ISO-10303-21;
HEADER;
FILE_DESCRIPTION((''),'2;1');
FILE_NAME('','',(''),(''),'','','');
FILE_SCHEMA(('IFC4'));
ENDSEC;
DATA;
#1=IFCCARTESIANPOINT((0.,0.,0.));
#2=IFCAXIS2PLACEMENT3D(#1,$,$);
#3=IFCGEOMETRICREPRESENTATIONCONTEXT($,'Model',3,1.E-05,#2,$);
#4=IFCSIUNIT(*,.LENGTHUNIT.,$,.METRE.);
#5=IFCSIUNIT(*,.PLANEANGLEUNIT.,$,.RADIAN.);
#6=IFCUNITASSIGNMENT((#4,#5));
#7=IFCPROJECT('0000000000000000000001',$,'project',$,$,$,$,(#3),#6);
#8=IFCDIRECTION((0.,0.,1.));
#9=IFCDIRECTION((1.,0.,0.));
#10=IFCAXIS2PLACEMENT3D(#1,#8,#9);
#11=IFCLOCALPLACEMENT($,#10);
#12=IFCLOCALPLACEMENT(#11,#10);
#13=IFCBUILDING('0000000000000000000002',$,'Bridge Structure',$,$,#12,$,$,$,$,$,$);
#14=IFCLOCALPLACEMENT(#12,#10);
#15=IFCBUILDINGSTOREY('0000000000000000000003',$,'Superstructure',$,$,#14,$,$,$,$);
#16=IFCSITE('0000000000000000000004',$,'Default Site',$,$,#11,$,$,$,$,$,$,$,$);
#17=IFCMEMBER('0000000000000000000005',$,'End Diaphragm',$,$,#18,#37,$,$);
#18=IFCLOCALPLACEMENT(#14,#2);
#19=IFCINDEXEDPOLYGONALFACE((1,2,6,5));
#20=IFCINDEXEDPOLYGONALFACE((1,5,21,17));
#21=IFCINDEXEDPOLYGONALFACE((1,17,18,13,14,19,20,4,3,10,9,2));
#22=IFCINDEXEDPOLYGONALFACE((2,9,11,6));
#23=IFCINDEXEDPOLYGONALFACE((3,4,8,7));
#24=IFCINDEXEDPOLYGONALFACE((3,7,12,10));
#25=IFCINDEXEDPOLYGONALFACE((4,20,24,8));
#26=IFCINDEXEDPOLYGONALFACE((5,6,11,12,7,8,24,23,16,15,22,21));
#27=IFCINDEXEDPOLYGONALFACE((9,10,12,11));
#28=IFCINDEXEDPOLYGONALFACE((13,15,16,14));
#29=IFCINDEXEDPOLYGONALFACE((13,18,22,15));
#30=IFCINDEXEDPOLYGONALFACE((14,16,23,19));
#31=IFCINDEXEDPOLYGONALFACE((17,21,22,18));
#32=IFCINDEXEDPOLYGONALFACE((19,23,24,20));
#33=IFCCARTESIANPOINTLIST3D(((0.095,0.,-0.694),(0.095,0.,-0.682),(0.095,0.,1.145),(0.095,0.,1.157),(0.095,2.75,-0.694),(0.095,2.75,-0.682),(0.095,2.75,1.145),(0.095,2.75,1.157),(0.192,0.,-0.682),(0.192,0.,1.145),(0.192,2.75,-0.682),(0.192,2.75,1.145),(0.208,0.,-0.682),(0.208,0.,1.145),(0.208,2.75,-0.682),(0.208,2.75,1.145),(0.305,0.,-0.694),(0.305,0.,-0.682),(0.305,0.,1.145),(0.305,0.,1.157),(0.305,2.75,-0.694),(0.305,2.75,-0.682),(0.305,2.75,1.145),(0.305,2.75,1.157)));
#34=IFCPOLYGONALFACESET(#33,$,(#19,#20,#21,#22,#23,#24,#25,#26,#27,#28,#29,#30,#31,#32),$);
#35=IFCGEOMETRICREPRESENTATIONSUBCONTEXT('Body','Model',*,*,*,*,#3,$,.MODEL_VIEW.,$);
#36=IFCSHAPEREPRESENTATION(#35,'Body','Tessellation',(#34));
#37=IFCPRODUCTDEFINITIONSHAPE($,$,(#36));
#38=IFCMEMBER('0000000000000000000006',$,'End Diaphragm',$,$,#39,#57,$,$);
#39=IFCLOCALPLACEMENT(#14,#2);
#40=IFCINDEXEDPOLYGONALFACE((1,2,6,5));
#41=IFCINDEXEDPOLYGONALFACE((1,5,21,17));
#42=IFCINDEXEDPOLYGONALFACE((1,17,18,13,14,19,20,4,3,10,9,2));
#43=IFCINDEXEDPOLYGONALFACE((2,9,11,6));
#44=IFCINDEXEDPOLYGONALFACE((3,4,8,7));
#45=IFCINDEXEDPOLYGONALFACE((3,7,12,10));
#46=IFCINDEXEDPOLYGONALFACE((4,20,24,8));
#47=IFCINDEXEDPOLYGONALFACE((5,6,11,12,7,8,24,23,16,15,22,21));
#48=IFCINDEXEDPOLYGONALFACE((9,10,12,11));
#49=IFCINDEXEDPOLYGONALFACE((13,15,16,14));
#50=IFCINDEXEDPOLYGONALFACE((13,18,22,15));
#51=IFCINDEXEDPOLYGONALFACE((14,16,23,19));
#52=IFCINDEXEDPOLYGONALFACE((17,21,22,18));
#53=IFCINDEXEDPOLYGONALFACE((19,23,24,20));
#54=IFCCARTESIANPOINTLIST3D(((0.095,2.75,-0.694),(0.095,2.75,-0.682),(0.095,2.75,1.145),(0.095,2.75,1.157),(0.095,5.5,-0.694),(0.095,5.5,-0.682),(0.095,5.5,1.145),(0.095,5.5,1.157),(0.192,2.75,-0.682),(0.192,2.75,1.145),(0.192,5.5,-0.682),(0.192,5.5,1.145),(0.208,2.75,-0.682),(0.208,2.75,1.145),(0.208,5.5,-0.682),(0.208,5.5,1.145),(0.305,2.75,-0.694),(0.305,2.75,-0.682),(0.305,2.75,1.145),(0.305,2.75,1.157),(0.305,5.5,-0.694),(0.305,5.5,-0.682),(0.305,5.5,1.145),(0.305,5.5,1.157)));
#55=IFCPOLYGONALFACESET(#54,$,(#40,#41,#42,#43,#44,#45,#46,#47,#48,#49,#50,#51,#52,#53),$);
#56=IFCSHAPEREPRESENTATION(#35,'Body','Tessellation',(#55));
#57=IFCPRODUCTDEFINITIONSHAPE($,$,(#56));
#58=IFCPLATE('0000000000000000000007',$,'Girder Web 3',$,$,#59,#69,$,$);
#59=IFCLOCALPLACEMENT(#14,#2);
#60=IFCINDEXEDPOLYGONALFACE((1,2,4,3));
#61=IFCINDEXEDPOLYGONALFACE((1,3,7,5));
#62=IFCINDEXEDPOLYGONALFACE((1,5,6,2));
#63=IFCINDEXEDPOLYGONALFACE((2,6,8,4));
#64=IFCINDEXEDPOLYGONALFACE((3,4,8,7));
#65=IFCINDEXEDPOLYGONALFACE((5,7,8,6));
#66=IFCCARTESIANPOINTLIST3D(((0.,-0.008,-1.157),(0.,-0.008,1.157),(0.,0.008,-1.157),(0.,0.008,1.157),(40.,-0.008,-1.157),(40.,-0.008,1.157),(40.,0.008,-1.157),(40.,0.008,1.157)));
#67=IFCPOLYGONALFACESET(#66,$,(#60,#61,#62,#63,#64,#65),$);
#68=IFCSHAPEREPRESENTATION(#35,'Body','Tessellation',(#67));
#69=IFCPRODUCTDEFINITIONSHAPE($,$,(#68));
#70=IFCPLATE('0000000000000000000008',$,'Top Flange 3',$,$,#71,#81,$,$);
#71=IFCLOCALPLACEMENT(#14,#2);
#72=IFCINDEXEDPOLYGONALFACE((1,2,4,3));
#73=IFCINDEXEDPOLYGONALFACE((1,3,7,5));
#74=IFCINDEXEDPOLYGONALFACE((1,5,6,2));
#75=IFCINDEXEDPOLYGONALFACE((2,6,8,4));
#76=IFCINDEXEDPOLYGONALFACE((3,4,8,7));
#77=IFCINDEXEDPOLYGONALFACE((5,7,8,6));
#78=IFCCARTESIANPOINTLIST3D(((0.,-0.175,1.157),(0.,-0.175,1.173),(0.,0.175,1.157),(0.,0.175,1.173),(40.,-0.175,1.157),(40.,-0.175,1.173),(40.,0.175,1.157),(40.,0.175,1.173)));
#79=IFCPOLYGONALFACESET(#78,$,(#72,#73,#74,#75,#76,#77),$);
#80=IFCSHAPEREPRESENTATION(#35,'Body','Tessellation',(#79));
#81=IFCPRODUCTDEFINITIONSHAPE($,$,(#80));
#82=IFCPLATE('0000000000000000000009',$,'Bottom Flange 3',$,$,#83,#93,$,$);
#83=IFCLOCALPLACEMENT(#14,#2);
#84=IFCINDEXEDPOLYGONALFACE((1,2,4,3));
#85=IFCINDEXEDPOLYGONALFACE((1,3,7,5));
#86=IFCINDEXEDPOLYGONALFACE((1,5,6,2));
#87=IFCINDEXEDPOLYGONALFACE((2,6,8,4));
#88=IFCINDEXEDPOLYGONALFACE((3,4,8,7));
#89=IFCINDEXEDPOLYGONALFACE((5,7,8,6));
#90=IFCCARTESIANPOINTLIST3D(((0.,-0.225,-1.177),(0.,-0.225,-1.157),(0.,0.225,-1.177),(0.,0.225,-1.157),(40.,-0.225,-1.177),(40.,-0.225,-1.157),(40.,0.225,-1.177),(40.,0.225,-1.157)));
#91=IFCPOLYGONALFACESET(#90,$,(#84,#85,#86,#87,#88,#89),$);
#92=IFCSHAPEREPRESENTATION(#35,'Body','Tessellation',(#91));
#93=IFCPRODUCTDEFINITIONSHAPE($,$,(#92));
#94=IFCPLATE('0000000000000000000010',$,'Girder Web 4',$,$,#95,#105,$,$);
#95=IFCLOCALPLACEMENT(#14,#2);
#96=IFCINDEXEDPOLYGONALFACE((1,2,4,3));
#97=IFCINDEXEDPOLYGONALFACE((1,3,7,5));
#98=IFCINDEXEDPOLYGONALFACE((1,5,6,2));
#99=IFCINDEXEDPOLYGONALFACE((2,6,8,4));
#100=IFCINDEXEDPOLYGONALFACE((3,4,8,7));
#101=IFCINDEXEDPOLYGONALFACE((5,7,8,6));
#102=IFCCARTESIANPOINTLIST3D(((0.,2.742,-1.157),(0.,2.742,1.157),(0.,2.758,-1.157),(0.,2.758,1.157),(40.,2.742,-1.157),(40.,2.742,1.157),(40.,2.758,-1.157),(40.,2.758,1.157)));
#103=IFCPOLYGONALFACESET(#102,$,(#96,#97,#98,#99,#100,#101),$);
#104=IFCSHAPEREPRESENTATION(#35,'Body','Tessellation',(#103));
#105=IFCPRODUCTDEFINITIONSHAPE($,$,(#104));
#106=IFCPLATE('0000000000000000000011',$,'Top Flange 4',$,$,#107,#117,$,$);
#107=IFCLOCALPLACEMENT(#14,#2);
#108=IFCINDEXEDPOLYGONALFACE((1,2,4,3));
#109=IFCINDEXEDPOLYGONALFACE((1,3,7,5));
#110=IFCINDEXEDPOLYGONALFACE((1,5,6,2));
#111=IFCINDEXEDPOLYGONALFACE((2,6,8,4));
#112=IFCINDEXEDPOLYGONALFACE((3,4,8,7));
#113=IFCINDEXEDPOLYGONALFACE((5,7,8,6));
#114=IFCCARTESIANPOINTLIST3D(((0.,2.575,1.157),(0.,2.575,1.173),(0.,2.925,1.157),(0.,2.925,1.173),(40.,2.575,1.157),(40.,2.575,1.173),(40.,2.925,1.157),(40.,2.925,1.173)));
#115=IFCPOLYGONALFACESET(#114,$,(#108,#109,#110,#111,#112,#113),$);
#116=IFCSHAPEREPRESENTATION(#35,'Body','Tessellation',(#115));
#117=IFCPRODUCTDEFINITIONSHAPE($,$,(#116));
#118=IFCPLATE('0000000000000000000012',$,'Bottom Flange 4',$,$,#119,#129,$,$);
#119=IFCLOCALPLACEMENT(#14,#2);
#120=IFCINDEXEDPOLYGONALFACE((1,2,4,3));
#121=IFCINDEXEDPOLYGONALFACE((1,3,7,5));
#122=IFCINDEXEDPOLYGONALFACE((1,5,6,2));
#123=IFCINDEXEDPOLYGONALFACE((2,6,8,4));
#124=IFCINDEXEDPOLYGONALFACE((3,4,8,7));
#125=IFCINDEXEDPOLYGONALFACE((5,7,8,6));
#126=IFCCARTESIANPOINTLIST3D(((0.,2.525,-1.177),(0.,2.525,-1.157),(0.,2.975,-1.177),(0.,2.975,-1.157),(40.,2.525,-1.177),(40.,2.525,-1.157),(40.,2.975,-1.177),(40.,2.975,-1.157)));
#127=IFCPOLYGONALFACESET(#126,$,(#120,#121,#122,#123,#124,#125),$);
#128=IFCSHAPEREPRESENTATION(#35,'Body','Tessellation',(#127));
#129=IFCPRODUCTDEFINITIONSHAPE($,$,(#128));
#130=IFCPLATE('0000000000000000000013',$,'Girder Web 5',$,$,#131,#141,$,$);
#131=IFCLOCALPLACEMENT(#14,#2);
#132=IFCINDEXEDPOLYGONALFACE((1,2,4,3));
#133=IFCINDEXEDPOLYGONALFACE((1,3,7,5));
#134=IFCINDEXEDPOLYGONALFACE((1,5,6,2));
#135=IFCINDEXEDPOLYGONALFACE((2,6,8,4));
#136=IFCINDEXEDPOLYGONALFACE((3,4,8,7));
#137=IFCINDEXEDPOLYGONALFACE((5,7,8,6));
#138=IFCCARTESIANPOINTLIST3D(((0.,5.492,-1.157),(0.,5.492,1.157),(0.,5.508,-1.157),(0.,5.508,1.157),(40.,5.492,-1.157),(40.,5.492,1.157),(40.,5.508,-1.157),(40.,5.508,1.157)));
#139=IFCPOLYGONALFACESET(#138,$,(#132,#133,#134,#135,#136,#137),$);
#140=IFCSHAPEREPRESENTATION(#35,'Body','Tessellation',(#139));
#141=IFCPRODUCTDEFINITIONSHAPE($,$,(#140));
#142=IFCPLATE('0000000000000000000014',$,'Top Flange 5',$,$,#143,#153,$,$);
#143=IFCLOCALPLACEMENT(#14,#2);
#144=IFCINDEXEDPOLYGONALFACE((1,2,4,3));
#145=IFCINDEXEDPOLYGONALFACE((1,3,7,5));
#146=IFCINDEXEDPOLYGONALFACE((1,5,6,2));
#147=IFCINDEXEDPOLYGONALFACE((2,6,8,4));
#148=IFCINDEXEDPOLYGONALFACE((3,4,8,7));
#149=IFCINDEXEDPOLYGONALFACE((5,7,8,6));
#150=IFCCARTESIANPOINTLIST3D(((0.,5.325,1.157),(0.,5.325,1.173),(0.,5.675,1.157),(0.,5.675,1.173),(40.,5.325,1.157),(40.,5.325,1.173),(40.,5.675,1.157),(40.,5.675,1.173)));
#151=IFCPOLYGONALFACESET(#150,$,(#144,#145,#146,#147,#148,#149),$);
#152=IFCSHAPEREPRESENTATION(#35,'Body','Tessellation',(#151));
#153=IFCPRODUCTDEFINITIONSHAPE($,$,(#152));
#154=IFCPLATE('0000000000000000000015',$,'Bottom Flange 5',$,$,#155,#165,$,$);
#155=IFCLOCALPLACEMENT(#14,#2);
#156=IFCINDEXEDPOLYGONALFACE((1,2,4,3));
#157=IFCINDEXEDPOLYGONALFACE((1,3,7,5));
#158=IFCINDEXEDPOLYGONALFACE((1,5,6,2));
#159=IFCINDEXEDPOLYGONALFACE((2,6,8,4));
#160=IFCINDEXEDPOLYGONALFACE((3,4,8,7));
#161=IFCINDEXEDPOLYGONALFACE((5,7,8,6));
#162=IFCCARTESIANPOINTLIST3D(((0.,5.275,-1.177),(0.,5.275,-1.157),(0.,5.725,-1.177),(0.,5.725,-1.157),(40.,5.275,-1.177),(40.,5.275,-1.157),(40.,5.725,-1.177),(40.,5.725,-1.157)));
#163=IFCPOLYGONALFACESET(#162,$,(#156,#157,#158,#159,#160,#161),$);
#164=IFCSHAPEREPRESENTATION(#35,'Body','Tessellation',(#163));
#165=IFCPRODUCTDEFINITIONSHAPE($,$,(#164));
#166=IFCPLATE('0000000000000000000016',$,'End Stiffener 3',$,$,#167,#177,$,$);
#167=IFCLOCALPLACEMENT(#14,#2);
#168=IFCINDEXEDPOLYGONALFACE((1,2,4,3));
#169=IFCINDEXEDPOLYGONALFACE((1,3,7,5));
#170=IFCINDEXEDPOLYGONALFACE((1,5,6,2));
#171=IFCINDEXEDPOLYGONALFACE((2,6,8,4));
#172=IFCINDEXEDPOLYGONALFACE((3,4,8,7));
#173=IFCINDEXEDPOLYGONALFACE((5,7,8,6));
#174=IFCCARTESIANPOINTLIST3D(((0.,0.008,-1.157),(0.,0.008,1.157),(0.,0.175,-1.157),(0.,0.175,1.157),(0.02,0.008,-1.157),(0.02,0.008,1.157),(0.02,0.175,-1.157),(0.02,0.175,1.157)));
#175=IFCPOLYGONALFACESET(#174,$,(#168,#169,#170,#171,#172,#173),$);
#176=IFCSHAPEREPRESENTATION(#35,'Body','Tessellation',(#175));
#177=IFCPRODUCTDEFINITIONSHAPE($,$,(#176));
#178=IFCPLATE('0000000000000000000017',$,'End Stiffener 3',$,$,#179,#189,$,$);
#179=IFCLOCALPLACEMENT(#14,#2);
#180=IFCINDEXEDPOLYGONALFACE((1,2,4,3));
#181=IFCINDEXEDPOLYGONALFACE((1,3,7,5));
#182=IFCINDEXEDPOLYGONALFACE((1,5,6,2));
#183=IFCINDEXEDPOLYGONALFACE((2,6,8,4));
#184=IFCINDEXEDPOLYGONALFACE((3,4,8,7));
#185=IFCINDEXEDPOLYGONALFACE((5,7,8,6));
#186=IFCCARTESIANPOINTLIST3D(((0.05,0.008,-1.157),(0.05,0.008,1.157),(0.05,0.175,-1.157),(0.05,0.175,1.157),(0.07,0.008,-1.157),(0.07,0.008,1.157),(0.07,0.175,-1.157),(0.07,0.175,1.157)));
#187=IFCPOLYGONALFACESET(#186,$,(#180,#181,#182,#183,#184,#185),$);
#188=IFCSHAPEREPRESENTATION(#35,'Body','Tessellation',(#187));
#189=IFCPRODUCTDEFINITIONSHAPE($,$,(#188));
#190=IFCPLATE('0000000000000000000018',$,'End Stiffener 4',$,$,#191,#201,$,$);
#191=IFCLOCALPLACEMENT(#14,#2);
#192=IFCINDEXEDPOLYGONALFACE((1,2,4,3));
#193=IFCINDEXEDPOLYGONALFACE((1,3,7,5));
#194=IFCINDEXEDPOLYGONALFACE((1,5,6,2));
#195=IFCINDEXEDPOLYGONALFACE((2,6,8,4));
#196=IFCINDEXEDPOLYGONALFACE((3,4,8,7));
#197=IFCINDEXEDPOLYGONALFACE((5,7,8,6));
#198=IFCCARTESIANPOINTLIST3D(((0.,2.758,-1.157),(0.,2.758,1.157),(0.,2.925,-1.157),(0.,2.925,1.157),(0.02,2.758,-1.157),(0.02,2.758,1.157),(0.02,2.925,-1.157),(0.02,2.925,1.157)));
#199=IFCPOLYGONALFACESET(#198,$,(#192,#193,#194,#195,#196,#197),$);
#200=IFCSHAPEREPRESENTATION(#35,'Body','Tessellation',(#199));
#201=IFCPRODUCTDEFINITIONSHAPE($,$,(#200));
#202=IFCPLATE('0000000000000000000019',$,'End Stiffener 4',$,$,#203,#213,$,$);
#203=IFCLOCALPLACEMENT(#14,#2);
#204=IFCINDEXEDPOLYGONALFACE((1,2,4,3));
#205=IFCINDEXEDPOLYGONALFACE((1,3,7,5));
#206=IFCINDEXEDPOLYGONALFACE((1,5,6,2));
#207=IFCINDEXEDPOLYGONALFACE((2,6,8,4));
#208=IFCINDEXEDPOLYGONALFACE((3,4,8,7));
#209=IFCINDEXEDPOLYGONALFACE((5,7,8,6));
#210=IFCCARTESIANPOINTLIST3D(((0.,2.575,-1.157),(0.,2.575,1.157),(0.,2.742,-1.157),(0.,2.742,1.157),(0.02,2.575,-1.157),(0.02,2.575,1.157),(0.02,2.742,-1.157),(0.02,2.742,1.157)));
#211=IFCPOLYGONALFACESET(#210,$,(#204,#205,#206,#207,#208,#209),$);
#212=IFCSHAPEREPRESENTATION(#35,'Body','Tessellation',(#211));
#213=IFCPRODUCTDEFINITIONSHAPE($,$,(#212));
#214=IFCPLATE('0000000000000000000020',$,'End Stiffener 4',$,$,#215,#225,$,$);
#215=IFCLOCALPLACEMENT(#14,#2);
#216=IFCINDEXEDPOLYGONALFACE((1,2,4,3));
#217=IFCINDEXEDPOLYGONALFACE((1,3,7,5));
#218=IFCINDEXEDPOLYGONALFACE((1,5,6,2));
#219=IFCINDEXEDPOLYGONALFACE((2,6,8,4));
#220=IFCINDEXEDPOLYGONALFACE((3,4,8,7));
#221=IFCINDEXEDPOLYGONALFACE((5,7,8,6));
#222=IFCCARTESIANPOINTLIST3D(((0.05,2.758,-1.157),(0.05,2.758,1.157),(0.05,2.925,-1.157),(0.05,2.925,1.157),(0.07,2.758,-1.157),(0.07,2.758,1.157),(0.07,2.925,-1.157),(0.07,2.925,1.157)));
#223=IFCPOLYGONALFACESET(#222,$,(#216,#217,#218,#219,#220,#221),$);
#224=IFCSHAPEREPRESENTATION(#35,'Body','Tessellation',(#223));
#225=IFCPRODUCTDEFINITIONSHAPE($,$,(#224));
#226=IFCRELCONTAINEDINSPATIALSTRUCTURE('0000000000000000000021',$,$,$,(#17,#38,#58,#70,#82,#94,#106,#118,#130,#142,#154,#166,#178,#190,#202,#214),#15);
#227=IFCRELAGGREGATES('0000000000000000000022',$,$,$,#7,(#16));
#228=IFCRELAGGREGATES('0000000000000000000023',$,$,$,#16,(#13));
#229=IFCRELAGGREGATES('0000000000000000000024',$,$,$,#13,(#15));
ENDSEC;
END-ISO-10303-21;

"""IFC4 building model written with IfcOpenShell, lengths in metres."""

from ifc_helpers import new_model, si_unit, frame, origin, origin_with_axes, origin_2d_with_axis, place, context, subcontext, project, spatial, rectangle, i_section, extrude, element, save


model = new_model("IFC4")

# Units and contexts
model_context = context("Model", 3, precision=1e-05, world=origin())
body_context = subcontext(model_context, "Body", "Model", "MODEL_VIEW")
ifc_project = project(units=[si_unit("LENGTHUNIT", "METRE"), si_unit("PLANEANGLEUNIT", "RADIAN")], contexts=[model_context])

# Site, building, storey
site_placement = place(None, origin_with_axes())
site = spatial("IfcSite", under=ifc_project, at=site_placement, Name="Default Site")
building_placement = place(site_placement, origin_with_axes())
building = spatial("IfcBuilding", under=site, at=building_placement, Name="Bridge Structure")
storey_placement = place(building_placement, origin_with_axes())
storey = spatial("IfcBuildingStorey", under=building, at=storey_placement, Name="Superstructure")

# Members
for number, where, z_axis, x_axis, name in (
    (1, (0.2, 0.0, 0.2315), (0.0, 1.0, 0.0), (-1.0, 0.0, 0.0), "End Diaphragm"),
    (2, (0.2, 2.75, 0.2315), (0.0, 1.0, 0.0), (-1.0, 0.0, 0.0), "End Diaphragm"),
):
    element("IfcMember", number, at=place(storey_placement, frame(where, z_axis=z_axis, x_axis=x_axis)), inside=storey, Name=name, context=body_context, shape_type="SweptSolid", body=[
        extrude(i_section(OverallWidth=0.21, OverallDepth=1.851, WebThickness=0.016, FlangeThickness=0.012, at=origin_2d_with_axis()), origin_with_axes(), (0.0, 0.0, 1.0), 2.75),
    ])

# Plates
plate_1_placement = place(storey_placement, frame((0.0, 0.0, 0.0), z_axis=(1.0, 0.0, 0.0), x_axis=(0.0, 1.0, 0.0)))
element("IfcPlate", 3, at=plate_1_placement, inside=storey, Name="Girder Web 3", context=body_context, shape_type="SweptSolid", body=[
    extrude(rectangle(XDim=0.016, YDim=2.314, at=origin_2d_with_axis()), origin_with_axes(), (0.0, 0.0, 1.0), 40.0),
])
plate_2_placement = place(storey_placement, frame((0.0, 0.0, 1.165), z_axis=(1.0, 0.0, 0.0), x_axis=(0.0, 1.0, 0.0)))
element("IfcPlate", 4, at=plate_2_placement, inside=storey, Name="Top Flange 3", context=body_context, shape_type="SweptSolid", body=[
    extrude(rectangle(XDim=0.35, YDim=0.016, at=origin_2d_with_axis()), origin_with_axes(), (0.0, 0.0, 1.0), 40.0),
])
plate_3_placement = place(storey_placement, frame((0.0, 0.0, -1.167), z_axis=(1.0, 0.0, 0.0), x_axis=(0.0, 1.0, 0.0)))
element("IfcPlate", 5, at=plate_3_placement, inside=storey, Name="Bottom Flange 3", context=body_context, shape_type="SweptSolid", body=[
    extrude(rectangle(XDim=0.45, YDim=0.02, at=origin_2d_with_axis()), origin_with_axes(), (0.0, 0.0, 1.0), 40.0),
])
plate_4_placement = place(storey_placement, frame((0.0, 2.75, 0.0), z_axis=(1.0, 0.0, 0.0), x_axis=(0.0, 1.0, 0.0)))
element("IfcPlate", 6, at=plate_4_placement, inside=storey, Name="Girder Web 4", context=body_context, shape_type="SweptSolid", body=[
    extrude(rectangle(XDim=0.016, YDim=2.314, at=origin_2d_with_axis()), origin_with_axes(), (0.0, 0.0, 1.0), 40.0),
])
plate_5_placement = place(storey_placement, frame((0.0, 2.75, 1.165), z_axis=(1.0, 0.0, 0.0), x_axis=(0.0, 1.0, 0.0)))
element("IfcPlate", 7, at=plate_5_placement, inside=storey, Name="Top Flange 4", context=body_context, shape_type="SweptSolid", body=[
    extrude(rectangle(XDim=0.35, YDim=0.016, at=origin_2d_with_axis()), origin_with_axes(), (0.0, 0.0, 1.0), 40.0),
])
plate_6_placement = place(storey_placement, frame((0.0, 2.75, -1.167), z_axis=(1.0, 0.0, 0.0), x_axis=(0.0, 1.0, 0.0)))
element("IfcPlate", 8, at=plate_6_placement, inside=storey, Name="Bottom Flange 4", context=body_context, shape_type="SweptSolid", body=[
    extrude(rectangle(XDim=0.45, YDim=0.02, at=origin_2d_with_axis()), origin_with_axes(), (0.0, 0.0, 1.0), 40.0),
])
plate_7_placement = place(storey_placement, frame((0.0, 5.5, 0.0), z_axis=(1.0, 0.0, 0.0), x_axis=(0.0, 1.0, 0.0)))
element("IfcPlate", 9, at=plate_7_placement, inside=storey, Name="Girder Web 5", context=body_context, shape_type="SweptSolid", body=[
    extrude(rectangle(XDim=0.016, YDim=2.314, at=origin_2d_with_axis()), origin_with_axes(), (0.0, 0.0, 1.0), 40.0),
])
plate_8_placement = place(storey_placement, frame((0.0, 5.5, 1.165), z_axis=(1.0, 0.0, 0.0), x_axis=(0.0, 1.0, 0.0)))
element("IfcPlate", 10, at=plate_8_placement, inside=storey, Name="Top Flange 5", context=body_context, shape_type="SweptSolid", body=[
    extrude(rectangle(XDim=0.35, YDim=0.016, at=origin_2d_with_axis()), origin_with_axes(), (0.0, 0.0, 1.0), 40.0),
])
plate_9_placement = place(storey_placement, frame((0.0, 5.5, -1.167), z_axis=(1.0, 0.0, 0.0), x_axis=(0.0, 1.0, 0.0)))
element("IfcPlate", 11, at=plate_9_placement, inside=storey, Name="Bottom Flange 5", context=body_context, shape_type="SweptSolid", body=[
    extrude(rectangle(XDim=0.45, YDim=0.02, at=origin_2d_with_axis()), origin_with_axes(), (0.0, 0.0, 1.0), 40.0),
])
for number, where, z_axis, x_axis, name in (
    (12, (0.01, 0.0915, -1.157), (0.0, 0.0, 1.0), (1.0, 0.0, 0.0), "End Stiffener 3"),
    (13, (0.06, 0.0915, -1.157), (0.0, 0.0, 1.0), (1.0, 0.0, 0.0), "End Stiffener 3"),
    (14, (0.01, 2.8415, -1.157), (0.0, 0.0, 1.0), (1.0, 0.0, 0.0), "End Stiffener 4"),
    (15, (0.01, 2.6585, -1.157), (0.0, 0.0, 1.0), (1.0, 0.0, 0.0), "End Stiffener 4"),
    (16, (0.06, 2.8415, -1.157), (0.0, 0.0, 1.0), (1.0, 0.0, 0.0), "End Stiffener 4"),
):
    element("IfcPlate", number, at=place(storey_placement, frame(where, z_axis=z_axis, x_axis=x_axis)), inside=storey, Name=name, context=body_context, shape_type="SweptSolid", body=[
        extrude(rectangle(XDim=0.02, YDim=0.167, at=origin_2d_with_axis()), origin_with_axes(), (0.0, 0.0, 1.0), 2.314),
    ])

save(model, "model.ifc")
